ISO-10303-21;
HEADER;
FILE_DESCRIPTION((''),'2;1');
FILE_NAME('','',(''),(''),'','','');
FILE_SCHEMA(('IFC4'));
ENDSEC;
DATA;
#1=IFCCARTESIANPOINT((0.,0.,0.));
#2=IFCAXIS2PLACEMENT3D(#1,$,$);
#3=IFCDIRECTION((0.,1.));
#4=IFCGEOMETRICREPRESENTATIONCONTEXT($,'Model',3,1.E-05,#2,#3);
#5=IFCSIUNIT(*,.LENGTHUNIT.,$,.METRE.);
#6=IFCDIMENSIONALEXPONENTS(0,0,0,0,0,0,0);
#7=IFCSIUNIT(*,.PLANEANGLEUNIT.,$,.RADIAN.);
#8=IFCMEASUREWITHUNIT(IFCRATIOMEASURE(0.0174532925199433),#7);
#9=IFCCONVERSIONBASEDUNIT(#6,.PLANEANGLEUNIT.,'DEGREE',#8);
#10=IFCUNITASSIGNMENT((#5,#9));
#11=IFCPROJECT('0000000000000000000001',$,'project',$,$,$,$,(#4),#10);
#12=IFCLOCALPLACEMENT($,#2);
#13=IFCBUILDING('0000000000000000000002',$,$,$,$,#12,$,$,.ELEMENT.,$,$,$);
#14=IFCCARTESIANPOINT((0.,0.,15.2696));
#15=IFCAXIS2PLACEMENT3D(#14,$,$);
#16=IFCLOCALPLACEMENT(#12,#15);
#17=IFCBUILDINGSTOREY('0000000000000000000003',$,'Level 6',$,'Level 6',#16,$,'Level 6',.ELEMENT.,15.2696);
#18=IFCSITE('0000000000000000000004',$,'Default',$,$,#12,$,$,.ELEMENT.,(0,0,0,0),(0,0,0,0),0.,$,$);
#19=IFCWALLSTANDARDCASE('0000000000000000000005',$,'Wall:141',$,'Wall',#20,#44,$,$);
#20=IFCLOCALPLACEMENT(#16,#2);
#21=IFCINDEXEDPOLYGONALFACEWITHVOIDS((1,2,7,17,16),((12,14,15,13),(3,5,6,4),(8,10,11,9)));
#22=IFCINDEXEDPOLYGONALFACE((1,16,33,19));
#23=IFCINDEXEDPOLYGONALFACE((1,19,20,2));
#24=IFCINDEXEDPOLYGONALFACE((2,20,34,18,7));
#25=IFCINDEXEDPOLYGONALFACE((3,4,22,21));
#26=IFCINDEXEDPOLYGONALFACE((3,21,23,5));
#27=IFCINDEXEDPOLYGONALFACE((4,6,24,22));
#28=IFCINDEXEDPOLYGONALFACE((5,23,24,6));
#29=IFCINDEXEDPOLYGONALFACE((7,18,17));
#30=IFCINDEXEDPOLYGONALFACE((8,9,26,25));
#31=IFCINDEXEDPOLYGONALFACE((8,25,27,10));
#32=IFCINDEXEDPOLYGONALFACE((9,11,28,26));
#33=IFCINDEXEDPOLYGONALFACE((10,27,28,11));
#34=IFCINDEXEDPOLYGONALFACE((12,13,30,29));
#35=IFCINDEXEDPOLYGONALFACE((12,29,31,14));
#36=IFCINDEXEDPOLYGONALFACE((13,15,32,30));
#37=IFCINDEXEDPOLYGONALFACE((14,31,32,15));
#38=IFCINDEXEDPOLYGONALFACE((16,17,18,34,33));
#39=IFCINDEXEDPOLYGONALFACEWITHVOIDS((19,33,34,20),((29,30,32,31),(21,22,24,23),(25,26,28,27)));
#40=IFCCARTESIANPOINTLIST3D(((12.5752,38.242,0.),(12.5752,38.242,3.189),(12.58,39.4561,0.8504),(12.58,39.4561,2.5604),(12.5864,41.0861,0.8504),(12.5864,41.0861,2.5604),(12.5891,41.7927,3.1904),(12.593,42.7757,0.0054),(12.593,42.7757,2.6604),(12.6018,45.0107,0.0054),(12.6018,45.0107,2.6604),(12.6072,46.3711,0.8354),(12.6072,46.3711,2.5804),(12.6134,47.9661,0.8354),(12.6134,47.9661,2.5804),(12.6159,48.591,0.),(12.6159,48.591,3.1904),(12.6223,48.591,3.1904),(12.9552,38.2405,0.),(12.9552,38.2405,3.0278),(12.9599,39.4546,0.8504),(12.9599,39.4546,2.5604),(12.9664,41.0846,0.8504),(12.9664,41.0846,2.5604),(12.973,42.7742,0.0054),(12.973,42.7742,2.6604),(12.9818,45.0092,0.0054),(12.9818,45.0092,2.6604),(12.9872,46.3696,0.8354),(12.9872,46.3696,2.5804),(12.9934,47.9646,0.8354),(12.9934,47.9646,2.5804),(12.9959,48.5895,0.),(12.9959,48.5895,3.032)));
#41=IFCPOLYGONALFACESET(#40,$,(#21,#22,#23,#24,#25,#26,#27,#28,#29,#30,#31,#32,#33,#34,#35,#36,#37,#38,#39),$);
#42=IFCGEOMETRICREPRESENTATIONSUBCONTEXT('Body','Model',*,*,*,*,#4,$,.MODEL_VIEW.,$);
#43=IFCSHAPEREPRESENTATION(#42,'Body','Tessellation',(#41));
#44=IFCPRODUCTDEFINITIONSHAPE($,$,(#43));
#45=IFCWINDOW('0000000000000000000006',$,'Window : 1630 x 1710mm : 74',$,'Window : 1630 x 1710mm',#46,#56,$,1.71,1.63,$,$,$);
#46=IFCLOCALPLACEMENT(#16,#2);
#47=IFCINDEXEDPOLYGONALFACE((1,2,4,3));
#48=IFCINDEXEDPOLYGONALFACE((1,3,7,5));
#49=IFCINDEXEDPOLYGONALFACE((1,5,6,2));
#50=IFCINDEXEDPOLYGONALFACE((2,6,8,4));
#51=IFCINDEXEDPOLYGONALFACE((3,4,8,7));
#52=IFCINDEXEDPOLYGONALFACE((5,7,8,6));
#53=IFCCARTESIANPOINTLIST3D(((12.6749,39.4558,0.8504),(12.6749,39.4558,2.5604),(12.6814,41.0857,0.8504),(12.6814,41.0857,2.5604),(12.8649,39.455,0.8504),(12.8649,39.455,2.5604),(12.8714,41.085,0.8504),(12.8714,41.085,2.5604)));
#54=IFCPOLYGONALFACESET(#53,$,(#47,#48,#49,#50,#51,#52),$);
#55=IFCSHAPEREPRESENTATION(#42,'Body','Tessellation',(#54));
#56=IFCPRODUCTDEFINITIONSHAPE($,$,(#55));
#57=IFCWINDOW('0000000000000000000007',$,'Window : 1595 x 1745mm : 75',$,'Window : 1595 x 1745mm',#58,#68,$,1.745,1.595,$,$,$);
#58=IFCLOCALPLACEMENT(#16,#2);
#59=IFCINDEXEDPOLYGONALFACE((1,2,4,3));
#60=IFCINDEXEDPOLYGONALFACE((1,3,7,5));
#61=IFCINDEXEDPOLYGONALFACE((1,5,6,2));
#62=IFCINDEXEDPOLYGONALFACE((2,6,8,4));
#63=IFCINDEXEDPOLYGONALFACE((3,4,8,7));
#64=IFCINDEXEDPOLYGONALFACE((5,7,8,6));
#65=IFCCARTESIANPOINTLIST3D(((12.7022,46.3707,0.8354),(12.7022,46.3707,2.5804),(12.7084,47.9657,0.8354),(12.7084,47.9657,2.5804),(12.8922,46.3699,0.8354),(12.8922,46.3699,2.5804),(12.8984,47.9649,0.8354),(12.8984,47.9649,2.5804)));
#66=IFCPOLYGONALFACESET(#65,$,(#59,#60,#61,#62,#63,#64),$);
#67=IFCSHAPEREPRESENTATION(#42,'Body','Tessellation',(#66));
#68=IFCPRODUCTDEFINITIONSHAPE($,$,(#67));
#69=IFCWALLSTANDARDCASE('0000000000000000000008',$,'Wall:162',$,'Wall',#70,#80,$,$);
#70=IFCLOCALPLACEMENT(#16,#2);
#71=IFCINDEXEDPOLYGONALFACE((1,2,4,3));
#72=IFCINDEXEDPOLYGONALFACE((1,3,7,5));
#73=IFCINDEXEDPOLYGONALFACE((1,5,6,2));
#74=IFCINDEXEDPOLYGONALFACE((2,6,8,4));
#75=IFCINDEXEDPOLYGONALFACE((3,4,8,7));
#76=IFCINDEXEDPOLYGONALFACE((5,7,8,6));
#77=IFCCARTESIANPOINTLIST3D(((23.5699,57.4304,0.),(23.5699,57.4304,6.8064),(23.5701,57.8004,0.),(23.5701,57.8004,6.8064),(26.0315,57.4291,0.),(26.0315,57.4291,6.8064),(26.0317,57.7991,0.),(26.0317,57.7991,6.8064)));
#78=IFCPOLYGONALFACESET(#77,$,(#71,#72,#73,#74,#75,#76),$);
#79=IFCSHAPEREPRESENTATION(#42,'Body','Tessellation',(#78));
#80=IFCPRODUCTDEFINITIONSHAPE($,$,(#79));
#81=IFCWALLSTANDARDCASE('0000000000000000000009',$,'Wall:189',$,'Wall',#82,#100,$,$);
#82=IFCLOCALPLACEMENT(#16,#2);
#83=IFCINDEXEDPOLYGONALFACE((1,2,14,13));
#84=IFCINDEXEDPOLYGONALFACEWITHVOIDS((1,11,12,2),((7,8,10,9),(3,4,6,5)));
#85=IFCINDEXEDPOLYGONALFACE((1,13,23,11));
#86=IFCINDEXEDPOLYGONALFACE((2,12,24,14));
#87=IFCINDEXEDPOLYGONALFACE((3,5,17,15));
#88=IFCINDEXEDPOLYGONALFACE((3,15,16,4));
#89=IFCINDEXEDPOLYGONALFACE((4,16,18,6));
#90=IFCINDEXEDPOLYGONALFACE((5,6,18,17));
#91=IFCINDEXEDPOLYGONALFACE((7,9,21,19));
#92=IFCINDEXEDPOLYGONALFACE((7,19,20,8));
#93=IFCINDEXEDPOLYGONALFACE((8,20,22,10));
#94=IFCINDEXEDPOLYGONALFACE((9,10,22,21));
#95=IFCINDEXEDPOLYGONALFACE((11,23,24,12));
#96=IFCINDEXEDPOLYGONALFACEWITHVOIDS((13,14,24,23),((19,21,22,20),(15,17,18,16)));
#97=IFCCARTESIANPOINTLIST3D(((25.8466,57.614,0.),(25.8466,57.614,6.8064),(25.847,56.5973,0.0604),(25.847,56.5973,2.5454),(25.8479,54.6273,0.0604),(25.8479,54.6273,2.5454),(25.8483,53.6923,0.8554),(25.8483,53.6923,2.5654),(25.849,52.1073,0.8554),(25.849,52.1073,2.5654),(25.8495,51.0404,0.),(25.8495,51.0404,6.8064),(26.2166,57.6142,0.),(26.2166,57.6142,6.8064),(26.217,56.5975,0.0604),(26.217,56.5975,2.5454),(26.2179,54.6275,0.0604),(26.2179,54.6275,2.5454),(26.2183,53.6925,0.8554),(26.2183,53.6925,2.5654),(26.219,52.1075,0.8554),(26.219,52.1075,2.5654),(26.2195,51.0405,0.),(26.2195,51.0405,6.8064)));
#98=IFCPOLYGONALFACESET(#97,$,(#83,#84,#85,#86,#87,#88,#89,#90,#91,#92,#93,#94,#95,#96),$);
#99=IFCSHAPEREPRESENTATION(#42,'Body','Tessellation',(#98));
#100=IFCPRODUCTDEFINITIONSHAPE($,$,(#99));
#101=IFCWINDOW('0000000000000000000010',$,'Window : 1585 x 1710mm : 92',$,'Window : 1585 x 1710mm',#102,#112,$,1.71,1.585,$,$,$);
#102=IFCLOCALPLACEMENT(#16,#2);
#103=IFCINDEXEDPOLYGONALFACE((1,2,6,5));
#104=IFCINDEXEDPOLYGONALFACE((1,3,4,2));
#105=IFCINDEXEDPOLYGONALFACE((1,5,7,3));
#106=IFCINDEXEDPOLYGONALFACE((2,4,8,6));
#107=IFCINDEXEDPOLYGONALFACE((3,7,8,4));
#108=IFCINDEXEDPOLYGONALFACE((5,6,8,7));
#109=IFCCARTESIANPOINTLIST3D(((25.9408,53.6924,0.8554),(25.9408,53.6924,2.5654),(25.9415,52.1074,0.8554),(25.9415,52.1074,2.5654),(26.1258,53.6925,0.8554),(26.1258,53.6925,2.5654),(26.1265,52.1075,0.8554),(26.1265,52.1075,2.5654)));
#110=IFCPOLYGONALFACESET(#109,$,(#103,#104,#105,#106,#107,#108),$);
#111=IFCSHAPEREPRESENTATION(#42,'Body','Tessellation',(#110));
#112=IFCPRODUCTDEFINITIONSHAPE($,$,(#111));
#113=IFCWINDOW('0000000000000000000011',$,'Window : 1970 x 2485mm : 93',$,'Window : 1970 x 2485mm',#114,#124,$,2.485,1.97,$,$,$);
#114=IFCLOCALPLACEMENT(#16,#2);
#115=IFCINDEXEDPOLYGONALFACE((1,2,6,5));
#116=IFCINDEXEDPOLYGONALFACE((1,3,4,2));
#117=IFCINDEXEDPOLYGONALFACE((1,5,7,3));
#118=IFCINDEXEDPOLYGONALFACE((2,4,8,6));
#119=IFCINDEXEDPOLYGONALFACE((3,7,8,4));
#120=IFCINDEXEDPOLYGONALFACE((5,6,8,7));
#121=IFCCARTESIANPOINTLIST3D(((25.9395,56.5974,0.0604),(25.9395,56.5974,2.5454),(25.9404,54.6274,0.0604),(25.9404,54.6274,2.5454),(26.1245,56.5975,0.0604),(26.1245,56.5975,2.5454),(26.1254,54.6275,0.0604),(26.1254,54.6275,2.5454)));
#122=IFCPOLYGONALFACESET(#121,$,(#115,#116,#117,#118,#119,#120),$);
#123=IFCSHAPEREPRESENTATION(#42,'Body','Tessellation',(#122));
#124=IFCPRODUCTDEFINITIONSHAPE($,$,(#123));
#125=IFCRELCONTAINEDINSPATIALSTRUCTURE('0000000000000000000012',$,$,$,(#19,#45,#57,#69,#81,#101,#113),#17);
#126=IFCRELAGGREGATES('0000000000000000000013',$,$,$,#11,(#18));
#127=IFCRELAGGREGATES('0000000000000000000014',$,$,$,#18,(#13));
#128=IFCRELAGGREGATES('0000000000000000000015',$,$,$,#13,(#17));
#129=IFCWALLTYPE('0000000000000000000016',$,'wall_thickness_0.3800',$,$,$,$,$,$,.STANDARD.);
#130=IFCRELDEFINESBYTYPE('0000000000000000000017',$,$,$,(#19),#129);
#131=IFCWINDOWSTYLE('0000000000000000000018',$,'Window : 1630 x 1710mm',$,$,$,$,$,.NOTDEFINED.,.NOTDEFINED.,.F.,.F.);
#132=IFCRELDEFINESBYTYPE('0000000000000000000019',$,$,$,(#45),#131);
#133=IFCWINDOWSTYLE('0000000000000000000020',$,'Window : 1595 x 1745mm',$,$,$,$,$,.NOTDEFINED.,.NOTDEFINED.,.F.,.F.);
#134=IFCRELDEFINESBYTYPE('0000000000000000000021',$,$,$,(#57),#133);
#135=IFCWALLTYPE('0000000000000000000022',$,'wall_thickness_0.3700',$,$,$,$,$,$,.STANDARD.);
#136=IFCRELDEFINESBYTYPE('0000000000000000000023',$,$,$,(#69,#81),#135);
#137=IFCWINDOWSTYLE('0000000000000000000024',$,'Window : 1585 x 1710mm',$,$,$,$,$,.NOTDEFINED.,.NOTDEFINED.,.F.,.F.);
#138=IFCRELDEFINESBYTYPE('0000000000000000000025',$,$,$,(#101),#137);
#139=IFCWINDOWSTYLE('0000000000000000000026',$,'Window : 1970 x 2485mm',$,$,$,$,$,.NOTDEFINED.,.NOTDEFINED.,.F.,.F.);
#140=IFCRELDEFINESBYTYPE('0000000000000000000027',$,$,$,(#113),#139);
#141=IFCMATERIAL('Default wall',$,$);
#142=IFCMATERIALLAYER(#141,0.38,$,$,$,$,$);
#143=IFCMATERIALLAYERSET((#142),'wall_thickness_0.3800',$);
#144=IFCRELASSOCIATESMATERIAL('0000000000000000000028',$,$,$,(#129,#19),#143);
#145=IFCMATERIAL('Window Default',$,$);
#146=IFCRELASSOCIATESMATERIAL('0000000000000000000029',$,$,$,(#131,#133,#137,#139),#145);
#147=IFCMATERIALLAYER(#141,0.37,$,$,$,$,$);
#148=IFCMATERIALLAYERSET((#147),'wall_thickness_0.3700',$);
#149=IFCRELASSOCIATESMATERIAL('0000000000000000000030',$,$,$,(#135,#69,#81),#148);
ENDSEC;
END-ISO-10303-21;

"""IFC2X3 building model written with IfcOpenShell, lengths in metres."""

from ifc_helpers import new_model, entity, si_unit, converted_unit, direction, frame, frame_2d, origin, origin_2d_with_axis, place, context, subcontext, project, spatial, polyline, rectangle, outline, extrude, clip, halfspace, source, transform, mapped, material, layer, layer_set, layer_usage, type_object, type_shapes, element, fill, save


model = new_model("IFC2X3")

# Units and contexts
model_context = context("Model", 3, precision=1e-05, world=origin(), true_north=direction((0.0, 1.0)))
body_context = subcontext(model_context, "Body", "Model", "MODEL_VIEW")
ifc_project = project(units=[si_unit("LENGTHUNIT", "METRE"), converted_unit("PLANEANGLEUNIT", "DEGREE", entity("IfcRatioMeasure", 0.0174532925199433), si_unit("PLANEANGLEUNIT", "RADIAN"), dimensions=[0, 0, 0, 0, 0, 0, 0])], contexts=[model_context])

# Site, building, storey
placement = place(None, origin())
site = spatial("IfcSite", under=ifc_project, at=placement, Name="Default", CompositionType="ELEMENT", RefLatitude=(0, 0, 0, 0), RefLongitude=(0, 0, 0, 0), RefElevation=0.0)
building = spatial("IfcBuilding", under=site, at=placement, CompositionType="ELEMENT")
storey_placement = place(placement, frame((0.0, 0.0, 15.2696)))
storey = spatial("IfcBuildingStorey", under=building, at=storey_placement, Name="Level 6", ObjectType="Level 6", LongName="Level 6", CompositionType="ELEMENT", Elevation=15.2696)

# Shared definitions
ifc_material_1 = material(Name="Default wall")

# Shared definitions
ifc_material_2 = material(Name="Window Default")

# Wall, openings, windows
ifc_layer_1 = layer(ifc_material_1, 0.38)
ifc_layer_set_1 = layer_set([ifc_layer_1], Name="wall_thickness_0.3800")
ifc_layer_usage_1 = layer_usage(ifc_layer_set_1, "AXIS2", "POSITIVE", -0.19)
wall_type_1 = type_object("IfcWallType", Name="wall_thickness_0.3800", PredefinedType="STANDARD", material=ifc_layer_set_1)
wall_1_placement = place(storey_placement, frame((12.8059, 48.5903, 0.0), z_axis=(0.0, 0.0, 1.0), x_axis=(-0.003936, -0.999992, 0.0)))
wall_1 = element("IfcWallStandardCase", 1, at=wall_1_placement, inside=storey, type_object=wall_type_1, material=ifc_layer_usage_1, Name="Wall:141", ObjectType="Wall", context=body_context, shape_type="Clipping", body=[
    clip(extrude(outline(polyline([(10.3491, -0.19), (10.3491, 0.19), (0.0, 0.19), (0.0, -0.19), (10.3491, -0.19)])), origin(), (0.0, 0.0, 1.0), 3.1904), halfspace(frame((-28.6462, -0.1021, 3.1673), z_axis=(0.000367, 0.3905, 0.920603), x_axis=(0.672944, -0.68106, 0.288623)), False)),
])
opening_1_placement = place(wall_1_placement, frame((3.5804, -0.19, 0.0054)))
element("IfcOpeningElement", 2, at=opening_1_placement, cuts=wall_1, ObjectType="Opening", context=body_context, shape_type="SweptSolid", body=[
    extrude(rectangle(XDim=2.235, YDim=2.655, at=frame_2d((1.3275, 1.1175), x_axis=(0.0, 1.0))), frame((0.0, 0.0, 0.0), z_axis=(0.0, 1.0, 0.0), x_axis=(0.0, 0.0, 1.0)), (0.0, 0.0, 1.0), 0.38),
])
opening_2_placement = place(wall_1_placement, frame((7.505, -0.19, 0.8504)))
opening_2 = element("IfcOpeningElement", 3, at=opening_2_placement, cuts=wall_1, ObjectType="Opening", context=body_context, shape_type="SweptSolid", body=[
    extrude(rectangle(XDim=1.63, YDim=1.71, at=frame_2d((0.855, 0.815), x_axis=(0.0, 1.0))), frame((0.0, 0.0, 0.0), z_axis=(0.0, 1.0, 0.0), x_axis=(0.0, 0.0, 1.0)), (0.0, 0.0, 1.0), 0.38),
])
opening_3_placement = place(wall_1_placement, frame((0.625, -0.19, 0.8354)))
opening_3 = element("IfcOpeningElement", 4, at=opening_3_placement, cuts=wall_1, ObjectType="Opening", context=body_context, shape_type="SweptSolid", body=[
    extrude(rectangle(XDim=1.595, YDim=1.745, at=frame_2d((0.8725, 0.7975), x_axis=(0.0, 1.0))), frame((0.0, 0.0, 0.0), z_axis=(0.0, 1.0, 0.0), x_axis=(0.0, 0.0, 1.0)), (0.0, 0.0, 1.0), 0.38),
])
window_style_1 = type_object("IfcWindowStyle", Name="Window : 1630 x 1710mm", ConstructionType="NOTDEFINED", OperationType="NOTDEFINED", ParameterTakesPrecedence=False, Sizeable=False, material=ifc_material_2)
shared_shape_1 = source(origin(), body_context, "Body", "SweptSolid", [
    extrude(rectangle(XDim=0.19, YDim=1.63, at=origin_2d_with_axis()), frame((0.815, 0.19, 0.0), z_axis=(0.0, 0.0, 1.0), x_axis=(0.0, 1.0, 0.0)), (0.0, 0.0, 1.0), 1.71),
])
type_shapes(window_style_1, [shared_shape_1])
window_1_placement = place(opening_2_placement, origin())
window_1 = element("IfcWindow", 5, at=window_1_placement, inside=storey, type_object=window_style_1, Name="Window : 1630 x 1710mm : 74", ObjectType="Window : 1630 x 1710mm", OverallHeight=1.71, OverallWidth=1.63, context=body_context, shape_type="MappedRepresentation", body=[
    mapped(shared_shape_1, transform((0.0, 0.0, 0.0), scale=1.0)),
])
fill(opening_2, window_1)
window_style_2 = type_object("IfcWindowStyle", Name="Window : 1595 x 1745mm", ConstructionType="NOTDEFINED", OperationType="NOTDEFINED", ParameterTakesPrecedence=False, Sizeable=False, material=ifc_material_2)
shared_shape_2 = source(origin(), body_context, "Body", "SweptSolid", [
    extrude(rectangle(XDim=0.19, YDim=1.595, at=origin_2d_with_axis()), frame((0.7975, 0.19, 0.0), z_axis=(0.0, 0.0, 1.0), x_axis=(0.0, 1.0, 0.0)), (0.0, 0.0, 1.0), 1.745),
])
type_shapes(window_style_2, [shared_shape_2])
window_2_placement = place(opening_3_placement, origin())
window_2 = element("IfcWindow", 6, at=window_2_placement, inside=storey, type_object=window_style_2, Name="Window : 1595 x 1745mm : 75", ObjectType="Window : 1595 x 1745mm", OverallHeight=1.745, OverallWidth=1.595, context=body_context, shape_type="MappedRepresentation", body=[
    mapped(shared_shape_2, transform((0.0, 0.0, 0.0), scale=1.0)),
])
fill(opening_3, window_2)

# Wall
ifc_layer_2 = layer(ifc_material_1, 0.37)
ifc_layer_set_2 = layer_set([ifc_layer_2], Name="wall_thickness_0.3700")
ifc_layer_usage_2 = layer_usage(ifc_layer_set_2, "AXIS2", "POSITIVE", -0.185)
wall_type_2 = type_object("IfcWallType", Name="wall_thickness_0.3700", PredefinedType="STANDARD", material=ifc_layer_set_2)
wall_2_placement = place(storey_placement, frame((23.57, 57.6154, 0.0), z_axis=(0.0, 0.0, 1.0), x_axis=(1.0, -0.000553, 0.0)))
element("IfcWallStandardCase", 7, at=wall_2_placement, inside=storey, type_object=wall_type_2, material=ifc_layer_usage_2, Name="Wall:162", ObjectType="Wall", context=body_context, shape_type="SweptSolid", body=[
    extrude(outline(polyline([(2.4615, -0.185), (2.4615, 0.185), (0.0, 0.185), (0.0, -0.185), (2.4615, -0.185)])), origin(), (0.0, 0.0, 1.0), 6.8064),
])

# Wall, openings, windows
wall_3_placement = place(storey_placement, frame((26.0316, 57.6141, 0.0), z_axis=(0.0, 0.0, 1.0), x_axis=(0.000451, -1.0, 0.0)))
wall_3 = element("IfcWallStandardCase", 8, at=wall_3_placement, inside=storey, type_object=wall_type_2, material=ifc_layer_usage_2, Name="Wall:189", ObjectType="Wall", context=body_context, shape_type="SweptSolid", body=[
    extrude(outline(polyline([(6.5736, -0.185), (6.5736, 0.185), (0.0, 0.185), (0.0, -0.185), (6.5736, -0.185)])), origin(), (0.0, 0.0, 1.0), 6.8064),
])
opening_4_placement = place(wall_3_placement, frame((3.9217, -0.185, 0.8554)))
opening_4 = element("IfcOpeningElement", 9, at=opening_4_placement, cuts=wall_3, ObjectType="Opening", context=body_context, shape_type="SweptSolid", body=[
    extrude(rectangle(XDim=1.585, YDim=1.71, at=frame_2d((0.855, 0.7925), x_axis=(0.0, 1.0))), frame((0.0, 0.0, 0.0), z_axis=(0.0, 1.0, 0.0), x_axis=(0.0, 0.0, 1.0)), (0.0, 0.0, 1.0), 0.37),
])
opening_5_placement = place(wall_3_placement, frame((1.0167, -0.185, 0.0604)))
opening_5 = element("IfcOpeningElement", 10, at=opening_5_placement, cuts=wall_3, ObjectType="Opening", context=body_context, shape_type="SweptSolid", body=[
    extrude(rectangle(XDim=1.97, YDim=2.485, at=frame_2d((1.2425, 0.985), x_axis=(0.0, 1.0))), frame((0.0, 0.0, 0.0), z_axis=(0.0, 1.0, 0.0), x_axis=(0.0, 0.0, 1.0)), (0.0, 0.0, 1.0), 0.37),
])
window_style_3 = type_object("IfcWindowStyle", Name="Window : 1585 x 1710mm", ConstructionType="NOTDEFINED", OperationType="NOTDEFINED", ParameterTakesPrecedence=False, Sizeable=False, material=ifc_material_2)
shared_shape_3 = source(origin(), body_context, "Body", "SweptSolid", [
    extrude(rectangle(XDim=0.185, YDim=1.585, at=origin_2d_with_axis()), frame((0.7925, 0.185, 0.0), z_axis=(0.0, 0.0, 1.0), x_axis=(0.0, 1.0, 0.0)), (0.0, 0.0, 1.0), 1.71),
])
type_shapes(window_style_3, [shared_shape_3])
window_3_placement = place(opening_4_placement, origin())
window_3 = element("IfcWindow", 11, at=window_3_placement, inside=storey, type_object=window_style_3, Name="Window : 1585 x 1710mm : 92", ObjectType="Window : 1585 x 1710mm", OverallHeight=1.71, OverallWidth=1.585, context=body_context, shape_type="MappedRepresentation", body=[
    mapped(shared_shape_3, transform((0.0, 0.0, 0.0), scale=1.0)),
])
fill(opening_4, window_3)
window_style_4 = type_object("IfcWindowStyle", Name="Window : 1970 x 2485mm", ConstructionType="NOTDEFINED", OperationType="NOTDEFINED", ParameterTakesPrecedence=False, Sizeable=False, material=ifc_material_2)
shared_shape_4 = source(origin(), body_context, "Body", "SweptSolid", [
    extrude(rectangle(XDim=0.185, YDim=1.97, at=origin_2d_with_axis()), frame((0.985, 0.185, 0.0), z_axis=(0.0, 0.0, 1.0), x_axis=(0.0, 1.0, 0.0)), (0.0, 0.0, 1.0), 2.485),
])
type_shapes(window_style_4, [shared_shape_4])
window_4_placement = place(opening_5_placement, origin())
window_4 = element("IfcWindow", 12, at=window_4_placement, inside=storey, type_object=window_style_4, Name="Window : 1970 x 2485mm : 93", ObjectType="Window : 1970 x 2485mm", OverallHeight=2.485, OverallWidth=1.97, context=body_context, shape_type="MappedRepresentation", body=[
    mapped(shared_shape_4, transform((0.0, 0.0, 0.0), scale=1.0)),
])
fill(opening_5, window_4)

save(model, "model.ifc")
